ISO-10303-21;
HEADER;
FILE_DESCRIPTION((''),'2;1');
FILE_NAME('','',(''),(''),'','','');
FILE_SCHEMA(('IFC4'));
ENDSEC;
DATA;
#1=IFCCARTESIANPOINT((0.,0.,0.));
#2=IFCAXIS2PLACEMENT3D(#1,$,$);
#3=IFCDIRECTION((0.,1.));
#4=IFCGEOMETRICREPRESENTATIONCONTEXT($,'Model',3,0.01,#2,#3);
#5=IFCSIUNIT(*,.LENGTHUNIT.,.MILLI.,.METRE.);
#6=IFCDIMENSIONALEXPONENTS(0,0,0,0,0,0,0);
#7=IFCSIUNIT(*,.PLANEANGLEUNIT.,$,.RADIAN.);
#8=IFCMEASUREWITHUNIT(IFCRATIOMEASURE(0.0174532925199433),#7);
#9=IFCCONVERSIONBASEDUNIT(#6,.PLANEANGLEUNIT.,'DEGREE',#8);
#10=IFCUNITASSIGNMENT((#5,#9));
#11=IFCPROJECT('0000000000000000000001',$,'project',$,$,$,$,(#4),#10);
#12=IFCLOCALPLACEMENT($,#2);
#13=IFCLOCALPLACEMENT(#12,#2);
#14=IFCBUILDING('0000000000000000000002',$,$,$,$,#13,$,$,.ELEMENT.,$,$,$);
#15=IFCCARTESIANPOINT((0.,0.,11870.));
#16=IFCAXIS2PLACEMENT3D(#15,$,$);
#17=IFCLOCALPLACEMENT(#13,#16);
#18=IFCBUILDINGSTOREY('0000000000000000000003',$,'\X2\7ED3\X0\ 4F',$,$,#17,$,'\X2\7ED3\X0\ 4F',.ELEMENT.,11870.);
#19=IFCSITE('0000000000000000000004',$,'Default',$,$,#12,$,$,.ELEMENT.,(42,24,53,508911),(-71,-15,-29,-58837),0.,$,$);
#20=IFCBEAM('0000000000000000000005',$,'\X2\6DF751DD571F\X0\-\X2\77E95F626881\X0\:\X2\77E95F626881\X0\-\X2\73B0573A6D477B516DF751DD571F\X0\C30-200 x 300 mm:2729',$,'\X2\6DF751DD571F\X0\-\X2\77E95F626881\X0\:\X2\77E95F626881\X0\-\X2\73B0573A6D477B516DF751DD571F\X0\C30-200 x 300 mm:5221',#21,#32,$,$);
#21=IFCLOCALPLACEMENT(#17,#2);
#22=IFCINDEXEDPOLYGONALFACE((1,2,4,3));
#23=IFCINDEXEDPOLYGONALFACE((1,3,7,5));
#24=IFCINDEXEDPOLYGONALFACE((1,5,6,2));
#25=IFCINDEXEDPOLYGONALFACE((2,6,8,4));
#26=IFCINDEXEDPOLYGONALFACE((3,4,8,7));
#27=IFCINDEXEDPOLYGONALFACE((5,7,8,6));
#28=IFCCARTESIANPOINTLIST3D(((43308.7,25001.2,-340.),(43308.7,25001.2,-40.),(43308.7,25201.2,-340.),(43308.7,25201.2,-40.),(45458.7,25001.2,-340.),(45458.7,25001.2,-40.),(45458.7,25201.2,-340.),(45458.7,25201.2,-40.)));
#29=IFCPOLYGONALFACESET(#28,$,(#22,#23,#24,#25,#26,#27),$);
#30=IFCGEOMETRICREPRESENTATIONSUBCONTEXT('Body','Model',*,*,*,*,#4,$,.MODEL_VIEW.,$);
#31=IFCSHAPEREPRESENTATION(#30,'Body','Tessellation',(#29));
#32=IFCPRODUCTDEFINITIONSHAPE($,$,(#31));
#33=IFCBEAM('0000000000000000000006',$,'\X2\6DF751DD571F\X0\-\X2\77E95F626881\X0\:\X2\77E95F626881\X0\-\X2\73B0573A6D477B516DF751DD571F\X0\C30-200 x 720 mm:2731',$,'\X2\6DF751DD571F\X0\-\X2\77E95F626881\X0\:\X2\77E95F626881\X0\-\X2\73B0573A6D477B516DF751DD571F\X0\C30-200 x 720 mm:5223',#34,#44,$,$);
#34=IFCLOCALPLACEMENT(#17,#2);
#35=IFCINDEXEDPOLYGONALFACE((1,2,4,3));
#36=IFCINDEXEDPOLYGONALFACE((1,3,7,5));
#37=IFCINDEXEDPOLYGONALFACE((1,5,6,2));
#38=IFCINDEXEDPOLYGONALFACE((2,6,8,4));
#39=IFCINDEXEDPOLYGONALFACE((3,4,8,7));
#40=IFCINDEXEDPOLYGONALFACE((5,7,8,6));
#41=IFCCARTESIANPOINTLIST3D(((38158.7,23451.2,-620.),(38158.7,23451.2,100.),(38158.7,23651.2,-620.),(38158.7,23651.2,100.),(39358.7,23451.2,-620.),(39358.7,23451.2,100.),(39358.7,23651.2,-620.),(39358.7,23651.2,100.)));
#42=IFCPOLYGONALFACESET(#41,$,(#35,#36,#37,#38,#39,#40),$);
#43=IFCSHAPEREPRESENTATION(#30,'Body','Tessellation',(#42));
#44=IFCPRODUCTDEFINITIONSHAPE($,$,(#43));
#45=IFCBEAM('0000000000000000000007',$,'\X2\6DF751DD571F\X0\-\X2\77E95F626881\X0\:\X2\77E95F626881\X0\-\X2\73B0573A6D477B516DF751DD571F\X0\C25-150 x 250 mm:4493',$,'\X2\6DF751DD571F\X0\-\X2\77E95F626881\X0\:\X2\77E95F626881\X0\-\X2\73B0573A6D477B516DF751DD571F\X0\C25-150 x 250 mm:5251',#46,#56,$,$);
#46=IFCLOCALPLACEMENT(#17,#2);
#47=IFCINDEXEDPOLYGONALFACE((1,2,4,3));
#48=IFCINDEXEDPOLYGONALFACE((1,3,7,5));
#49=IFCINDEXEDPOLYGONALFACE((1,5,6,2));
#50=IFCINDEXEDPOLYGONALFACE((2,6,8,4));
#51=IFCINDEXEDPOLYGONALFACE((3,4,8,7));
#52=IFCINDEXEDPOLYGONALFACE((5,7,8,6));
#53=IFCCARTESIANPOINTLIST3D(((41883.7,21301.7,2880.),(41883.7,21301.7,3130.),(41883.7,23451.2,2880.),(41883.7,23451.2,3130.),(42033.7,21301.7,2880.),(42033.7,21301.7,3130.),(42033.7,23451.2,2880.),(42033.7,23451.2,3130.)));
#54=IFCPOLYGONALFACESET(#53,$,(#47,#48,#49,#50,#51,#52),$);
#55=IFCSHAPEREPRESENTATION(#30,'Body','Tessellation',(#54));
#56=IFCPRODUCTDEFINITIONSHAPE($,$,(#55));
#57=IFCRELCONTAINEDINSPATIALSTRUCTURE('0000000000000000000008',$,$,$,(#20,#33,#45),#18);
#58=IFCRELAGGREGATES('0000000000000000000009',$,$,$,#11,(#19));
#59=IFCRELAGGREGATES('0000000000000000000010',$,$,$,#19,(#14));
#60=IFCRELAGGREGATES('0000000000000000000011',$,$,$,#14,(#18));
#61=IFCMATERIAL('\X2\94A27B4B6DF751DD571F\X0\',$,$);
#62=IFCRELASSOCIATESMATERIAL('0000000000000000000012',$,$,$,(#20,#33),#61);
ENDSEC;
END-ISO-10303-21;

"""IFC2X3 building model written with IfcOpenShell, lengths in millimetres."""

from ifc_helpers import new_model, entity, si_unit, converted_unit, direction, frame, frame_2d, origin, place, context, subcontext, project, spatial, rectangle, extrude, material, element, save


model = new_model("IFC2X3")

# Units and contexts
model_context = context("Model", 3, precision=0.01, world=origin(), true_north=direction((0.0, 1.0)))
body_context = subcontext(model_context, "Body", "Model", "MODEL_VIEW")
ifc_project = project(units=[si_unit("LENGTHUNIT", "METRE", prefix="MILLI"), converted_unit("PLANEANGLEUNIT", "DEGREE", entity("IfcRatioMeasure", 0.0174532925199433), si_unit("PLANEANGLEUNIT", "RADIAN"), dimensions=[0, 0, 0, 0, 0, 0, 0])], contexts=[model_context])

# Site, building, storey
site_placement = place(None, origin())
site = spatial("IfcSite", under=ifc_project, at=site_placement, Name="Default", CompositionType="ELEMENT", RefLatitude=(42, 24, 53, 508911), RefLongitude=(-71, -15, -29, -58837), RefElevation=0.0)
building_placement = place(site_placement, origin())
building = spatial("IfcBuilding", under=site, at=building_placement, CompositionType="ELEMENT")
storey_placement = place(building_placement, frame((0.0, 0.0, 11870.0)))
storey = spatial("IfcBuildingStorey", under=building, at=storey_placement, Name="结 4F", LongName="结 4F", CompositionType="ELEMENT", Elevation=11870.0)

# Beams
ifc_material = material(Name="钢筋混凝土")
beam_1_placement = place(storey_placement, frame((43208.7, 25101.2, -40.0)))
element("IfcBeam", 1, at=beam_1_placement, inside=storey, material=ifc_material, Name="混凝土-矩形梁:矩形梁-现场浇筑混凝土C30-200 x 300 mm:2729", ObjectType="混凝土-矩形梁:矩形梁-现场浇筑混凝土C30-200 x 300 mm:5221", context=body_context, shape_type="SweptSolid", body=[
    extrude(rectangle(XDim=300.0, YDim=200.0, at=frame_2d((0.0, 0.0), x_axis=(1.0, 0.0))), frame((100.0, 0.0, -150.0), z_axis=(1.0, 0.0, 0.0), x_axis=(0.0, 0.0, -1.0)), (0.0, 0.0, 1.0), 2150.0),
])
beam_2_placement = place(storey_placement, frame((37408.7, 23551.2, 100.0)))
element("IfcBeam", 2, at=beam_2_placement, inside=storey, material=ifc_material, Name="混凝土-矩形梁:矩形梁-现场浇筑混凝土C30-200 x 720 mm:2731", ObjectType="混凝土-矩形梁:矩形梁-现场浇筑混凝土C30-200 x 720 mm:5223", context=body_context, shape_type="SweptSolid", body=[
    extrude(rectangle(XDim=720.0, YDim=200.0, at=frame_2d((0.0, 0.0), x_axis=(1.0, 0.0))), frame((750.0, 0.0, -360.0), z_axis=(1.0, 0.0, 0.0), x_axis=(0.0, 0.0, -1.0)), (0.0, 0.0, 1.0), 1200.1),
])
beam_3_placement = place(storey_placement, frame((41958.7, 21301.2, 3130.0), z_axis=(0.0, 0.0, 1.0), x_axis=(0.0, 1.0, 0.0)))
element("IfcBeam", 3, at=beam_3_placement, inside=storey, Name="混凝土-矩形梁:矩形梁-现场浇筑混凝土C25-150 x 250 mm:4493", ObjectType="混凝土-矩形梁:矩形梁-现场浇筑混凝土C25-150 x 250 mm:5251", context=body_context, shape_type="SweptSolid", body=[
    extrude(rectangle(XDim=250.0, YDim=150.0, at=frame_2d((0.0, 0.0), x_axis=(1.0, 0.0))), frame((0.5, 0.0, -125.0), z_axis=(1.0, 0.0, 0.0), x_axis=(0.0, 0.0, -1.0)), (0.0, 0.0, 1.0), 2149.5),
])

save(model, "model.ifc")
